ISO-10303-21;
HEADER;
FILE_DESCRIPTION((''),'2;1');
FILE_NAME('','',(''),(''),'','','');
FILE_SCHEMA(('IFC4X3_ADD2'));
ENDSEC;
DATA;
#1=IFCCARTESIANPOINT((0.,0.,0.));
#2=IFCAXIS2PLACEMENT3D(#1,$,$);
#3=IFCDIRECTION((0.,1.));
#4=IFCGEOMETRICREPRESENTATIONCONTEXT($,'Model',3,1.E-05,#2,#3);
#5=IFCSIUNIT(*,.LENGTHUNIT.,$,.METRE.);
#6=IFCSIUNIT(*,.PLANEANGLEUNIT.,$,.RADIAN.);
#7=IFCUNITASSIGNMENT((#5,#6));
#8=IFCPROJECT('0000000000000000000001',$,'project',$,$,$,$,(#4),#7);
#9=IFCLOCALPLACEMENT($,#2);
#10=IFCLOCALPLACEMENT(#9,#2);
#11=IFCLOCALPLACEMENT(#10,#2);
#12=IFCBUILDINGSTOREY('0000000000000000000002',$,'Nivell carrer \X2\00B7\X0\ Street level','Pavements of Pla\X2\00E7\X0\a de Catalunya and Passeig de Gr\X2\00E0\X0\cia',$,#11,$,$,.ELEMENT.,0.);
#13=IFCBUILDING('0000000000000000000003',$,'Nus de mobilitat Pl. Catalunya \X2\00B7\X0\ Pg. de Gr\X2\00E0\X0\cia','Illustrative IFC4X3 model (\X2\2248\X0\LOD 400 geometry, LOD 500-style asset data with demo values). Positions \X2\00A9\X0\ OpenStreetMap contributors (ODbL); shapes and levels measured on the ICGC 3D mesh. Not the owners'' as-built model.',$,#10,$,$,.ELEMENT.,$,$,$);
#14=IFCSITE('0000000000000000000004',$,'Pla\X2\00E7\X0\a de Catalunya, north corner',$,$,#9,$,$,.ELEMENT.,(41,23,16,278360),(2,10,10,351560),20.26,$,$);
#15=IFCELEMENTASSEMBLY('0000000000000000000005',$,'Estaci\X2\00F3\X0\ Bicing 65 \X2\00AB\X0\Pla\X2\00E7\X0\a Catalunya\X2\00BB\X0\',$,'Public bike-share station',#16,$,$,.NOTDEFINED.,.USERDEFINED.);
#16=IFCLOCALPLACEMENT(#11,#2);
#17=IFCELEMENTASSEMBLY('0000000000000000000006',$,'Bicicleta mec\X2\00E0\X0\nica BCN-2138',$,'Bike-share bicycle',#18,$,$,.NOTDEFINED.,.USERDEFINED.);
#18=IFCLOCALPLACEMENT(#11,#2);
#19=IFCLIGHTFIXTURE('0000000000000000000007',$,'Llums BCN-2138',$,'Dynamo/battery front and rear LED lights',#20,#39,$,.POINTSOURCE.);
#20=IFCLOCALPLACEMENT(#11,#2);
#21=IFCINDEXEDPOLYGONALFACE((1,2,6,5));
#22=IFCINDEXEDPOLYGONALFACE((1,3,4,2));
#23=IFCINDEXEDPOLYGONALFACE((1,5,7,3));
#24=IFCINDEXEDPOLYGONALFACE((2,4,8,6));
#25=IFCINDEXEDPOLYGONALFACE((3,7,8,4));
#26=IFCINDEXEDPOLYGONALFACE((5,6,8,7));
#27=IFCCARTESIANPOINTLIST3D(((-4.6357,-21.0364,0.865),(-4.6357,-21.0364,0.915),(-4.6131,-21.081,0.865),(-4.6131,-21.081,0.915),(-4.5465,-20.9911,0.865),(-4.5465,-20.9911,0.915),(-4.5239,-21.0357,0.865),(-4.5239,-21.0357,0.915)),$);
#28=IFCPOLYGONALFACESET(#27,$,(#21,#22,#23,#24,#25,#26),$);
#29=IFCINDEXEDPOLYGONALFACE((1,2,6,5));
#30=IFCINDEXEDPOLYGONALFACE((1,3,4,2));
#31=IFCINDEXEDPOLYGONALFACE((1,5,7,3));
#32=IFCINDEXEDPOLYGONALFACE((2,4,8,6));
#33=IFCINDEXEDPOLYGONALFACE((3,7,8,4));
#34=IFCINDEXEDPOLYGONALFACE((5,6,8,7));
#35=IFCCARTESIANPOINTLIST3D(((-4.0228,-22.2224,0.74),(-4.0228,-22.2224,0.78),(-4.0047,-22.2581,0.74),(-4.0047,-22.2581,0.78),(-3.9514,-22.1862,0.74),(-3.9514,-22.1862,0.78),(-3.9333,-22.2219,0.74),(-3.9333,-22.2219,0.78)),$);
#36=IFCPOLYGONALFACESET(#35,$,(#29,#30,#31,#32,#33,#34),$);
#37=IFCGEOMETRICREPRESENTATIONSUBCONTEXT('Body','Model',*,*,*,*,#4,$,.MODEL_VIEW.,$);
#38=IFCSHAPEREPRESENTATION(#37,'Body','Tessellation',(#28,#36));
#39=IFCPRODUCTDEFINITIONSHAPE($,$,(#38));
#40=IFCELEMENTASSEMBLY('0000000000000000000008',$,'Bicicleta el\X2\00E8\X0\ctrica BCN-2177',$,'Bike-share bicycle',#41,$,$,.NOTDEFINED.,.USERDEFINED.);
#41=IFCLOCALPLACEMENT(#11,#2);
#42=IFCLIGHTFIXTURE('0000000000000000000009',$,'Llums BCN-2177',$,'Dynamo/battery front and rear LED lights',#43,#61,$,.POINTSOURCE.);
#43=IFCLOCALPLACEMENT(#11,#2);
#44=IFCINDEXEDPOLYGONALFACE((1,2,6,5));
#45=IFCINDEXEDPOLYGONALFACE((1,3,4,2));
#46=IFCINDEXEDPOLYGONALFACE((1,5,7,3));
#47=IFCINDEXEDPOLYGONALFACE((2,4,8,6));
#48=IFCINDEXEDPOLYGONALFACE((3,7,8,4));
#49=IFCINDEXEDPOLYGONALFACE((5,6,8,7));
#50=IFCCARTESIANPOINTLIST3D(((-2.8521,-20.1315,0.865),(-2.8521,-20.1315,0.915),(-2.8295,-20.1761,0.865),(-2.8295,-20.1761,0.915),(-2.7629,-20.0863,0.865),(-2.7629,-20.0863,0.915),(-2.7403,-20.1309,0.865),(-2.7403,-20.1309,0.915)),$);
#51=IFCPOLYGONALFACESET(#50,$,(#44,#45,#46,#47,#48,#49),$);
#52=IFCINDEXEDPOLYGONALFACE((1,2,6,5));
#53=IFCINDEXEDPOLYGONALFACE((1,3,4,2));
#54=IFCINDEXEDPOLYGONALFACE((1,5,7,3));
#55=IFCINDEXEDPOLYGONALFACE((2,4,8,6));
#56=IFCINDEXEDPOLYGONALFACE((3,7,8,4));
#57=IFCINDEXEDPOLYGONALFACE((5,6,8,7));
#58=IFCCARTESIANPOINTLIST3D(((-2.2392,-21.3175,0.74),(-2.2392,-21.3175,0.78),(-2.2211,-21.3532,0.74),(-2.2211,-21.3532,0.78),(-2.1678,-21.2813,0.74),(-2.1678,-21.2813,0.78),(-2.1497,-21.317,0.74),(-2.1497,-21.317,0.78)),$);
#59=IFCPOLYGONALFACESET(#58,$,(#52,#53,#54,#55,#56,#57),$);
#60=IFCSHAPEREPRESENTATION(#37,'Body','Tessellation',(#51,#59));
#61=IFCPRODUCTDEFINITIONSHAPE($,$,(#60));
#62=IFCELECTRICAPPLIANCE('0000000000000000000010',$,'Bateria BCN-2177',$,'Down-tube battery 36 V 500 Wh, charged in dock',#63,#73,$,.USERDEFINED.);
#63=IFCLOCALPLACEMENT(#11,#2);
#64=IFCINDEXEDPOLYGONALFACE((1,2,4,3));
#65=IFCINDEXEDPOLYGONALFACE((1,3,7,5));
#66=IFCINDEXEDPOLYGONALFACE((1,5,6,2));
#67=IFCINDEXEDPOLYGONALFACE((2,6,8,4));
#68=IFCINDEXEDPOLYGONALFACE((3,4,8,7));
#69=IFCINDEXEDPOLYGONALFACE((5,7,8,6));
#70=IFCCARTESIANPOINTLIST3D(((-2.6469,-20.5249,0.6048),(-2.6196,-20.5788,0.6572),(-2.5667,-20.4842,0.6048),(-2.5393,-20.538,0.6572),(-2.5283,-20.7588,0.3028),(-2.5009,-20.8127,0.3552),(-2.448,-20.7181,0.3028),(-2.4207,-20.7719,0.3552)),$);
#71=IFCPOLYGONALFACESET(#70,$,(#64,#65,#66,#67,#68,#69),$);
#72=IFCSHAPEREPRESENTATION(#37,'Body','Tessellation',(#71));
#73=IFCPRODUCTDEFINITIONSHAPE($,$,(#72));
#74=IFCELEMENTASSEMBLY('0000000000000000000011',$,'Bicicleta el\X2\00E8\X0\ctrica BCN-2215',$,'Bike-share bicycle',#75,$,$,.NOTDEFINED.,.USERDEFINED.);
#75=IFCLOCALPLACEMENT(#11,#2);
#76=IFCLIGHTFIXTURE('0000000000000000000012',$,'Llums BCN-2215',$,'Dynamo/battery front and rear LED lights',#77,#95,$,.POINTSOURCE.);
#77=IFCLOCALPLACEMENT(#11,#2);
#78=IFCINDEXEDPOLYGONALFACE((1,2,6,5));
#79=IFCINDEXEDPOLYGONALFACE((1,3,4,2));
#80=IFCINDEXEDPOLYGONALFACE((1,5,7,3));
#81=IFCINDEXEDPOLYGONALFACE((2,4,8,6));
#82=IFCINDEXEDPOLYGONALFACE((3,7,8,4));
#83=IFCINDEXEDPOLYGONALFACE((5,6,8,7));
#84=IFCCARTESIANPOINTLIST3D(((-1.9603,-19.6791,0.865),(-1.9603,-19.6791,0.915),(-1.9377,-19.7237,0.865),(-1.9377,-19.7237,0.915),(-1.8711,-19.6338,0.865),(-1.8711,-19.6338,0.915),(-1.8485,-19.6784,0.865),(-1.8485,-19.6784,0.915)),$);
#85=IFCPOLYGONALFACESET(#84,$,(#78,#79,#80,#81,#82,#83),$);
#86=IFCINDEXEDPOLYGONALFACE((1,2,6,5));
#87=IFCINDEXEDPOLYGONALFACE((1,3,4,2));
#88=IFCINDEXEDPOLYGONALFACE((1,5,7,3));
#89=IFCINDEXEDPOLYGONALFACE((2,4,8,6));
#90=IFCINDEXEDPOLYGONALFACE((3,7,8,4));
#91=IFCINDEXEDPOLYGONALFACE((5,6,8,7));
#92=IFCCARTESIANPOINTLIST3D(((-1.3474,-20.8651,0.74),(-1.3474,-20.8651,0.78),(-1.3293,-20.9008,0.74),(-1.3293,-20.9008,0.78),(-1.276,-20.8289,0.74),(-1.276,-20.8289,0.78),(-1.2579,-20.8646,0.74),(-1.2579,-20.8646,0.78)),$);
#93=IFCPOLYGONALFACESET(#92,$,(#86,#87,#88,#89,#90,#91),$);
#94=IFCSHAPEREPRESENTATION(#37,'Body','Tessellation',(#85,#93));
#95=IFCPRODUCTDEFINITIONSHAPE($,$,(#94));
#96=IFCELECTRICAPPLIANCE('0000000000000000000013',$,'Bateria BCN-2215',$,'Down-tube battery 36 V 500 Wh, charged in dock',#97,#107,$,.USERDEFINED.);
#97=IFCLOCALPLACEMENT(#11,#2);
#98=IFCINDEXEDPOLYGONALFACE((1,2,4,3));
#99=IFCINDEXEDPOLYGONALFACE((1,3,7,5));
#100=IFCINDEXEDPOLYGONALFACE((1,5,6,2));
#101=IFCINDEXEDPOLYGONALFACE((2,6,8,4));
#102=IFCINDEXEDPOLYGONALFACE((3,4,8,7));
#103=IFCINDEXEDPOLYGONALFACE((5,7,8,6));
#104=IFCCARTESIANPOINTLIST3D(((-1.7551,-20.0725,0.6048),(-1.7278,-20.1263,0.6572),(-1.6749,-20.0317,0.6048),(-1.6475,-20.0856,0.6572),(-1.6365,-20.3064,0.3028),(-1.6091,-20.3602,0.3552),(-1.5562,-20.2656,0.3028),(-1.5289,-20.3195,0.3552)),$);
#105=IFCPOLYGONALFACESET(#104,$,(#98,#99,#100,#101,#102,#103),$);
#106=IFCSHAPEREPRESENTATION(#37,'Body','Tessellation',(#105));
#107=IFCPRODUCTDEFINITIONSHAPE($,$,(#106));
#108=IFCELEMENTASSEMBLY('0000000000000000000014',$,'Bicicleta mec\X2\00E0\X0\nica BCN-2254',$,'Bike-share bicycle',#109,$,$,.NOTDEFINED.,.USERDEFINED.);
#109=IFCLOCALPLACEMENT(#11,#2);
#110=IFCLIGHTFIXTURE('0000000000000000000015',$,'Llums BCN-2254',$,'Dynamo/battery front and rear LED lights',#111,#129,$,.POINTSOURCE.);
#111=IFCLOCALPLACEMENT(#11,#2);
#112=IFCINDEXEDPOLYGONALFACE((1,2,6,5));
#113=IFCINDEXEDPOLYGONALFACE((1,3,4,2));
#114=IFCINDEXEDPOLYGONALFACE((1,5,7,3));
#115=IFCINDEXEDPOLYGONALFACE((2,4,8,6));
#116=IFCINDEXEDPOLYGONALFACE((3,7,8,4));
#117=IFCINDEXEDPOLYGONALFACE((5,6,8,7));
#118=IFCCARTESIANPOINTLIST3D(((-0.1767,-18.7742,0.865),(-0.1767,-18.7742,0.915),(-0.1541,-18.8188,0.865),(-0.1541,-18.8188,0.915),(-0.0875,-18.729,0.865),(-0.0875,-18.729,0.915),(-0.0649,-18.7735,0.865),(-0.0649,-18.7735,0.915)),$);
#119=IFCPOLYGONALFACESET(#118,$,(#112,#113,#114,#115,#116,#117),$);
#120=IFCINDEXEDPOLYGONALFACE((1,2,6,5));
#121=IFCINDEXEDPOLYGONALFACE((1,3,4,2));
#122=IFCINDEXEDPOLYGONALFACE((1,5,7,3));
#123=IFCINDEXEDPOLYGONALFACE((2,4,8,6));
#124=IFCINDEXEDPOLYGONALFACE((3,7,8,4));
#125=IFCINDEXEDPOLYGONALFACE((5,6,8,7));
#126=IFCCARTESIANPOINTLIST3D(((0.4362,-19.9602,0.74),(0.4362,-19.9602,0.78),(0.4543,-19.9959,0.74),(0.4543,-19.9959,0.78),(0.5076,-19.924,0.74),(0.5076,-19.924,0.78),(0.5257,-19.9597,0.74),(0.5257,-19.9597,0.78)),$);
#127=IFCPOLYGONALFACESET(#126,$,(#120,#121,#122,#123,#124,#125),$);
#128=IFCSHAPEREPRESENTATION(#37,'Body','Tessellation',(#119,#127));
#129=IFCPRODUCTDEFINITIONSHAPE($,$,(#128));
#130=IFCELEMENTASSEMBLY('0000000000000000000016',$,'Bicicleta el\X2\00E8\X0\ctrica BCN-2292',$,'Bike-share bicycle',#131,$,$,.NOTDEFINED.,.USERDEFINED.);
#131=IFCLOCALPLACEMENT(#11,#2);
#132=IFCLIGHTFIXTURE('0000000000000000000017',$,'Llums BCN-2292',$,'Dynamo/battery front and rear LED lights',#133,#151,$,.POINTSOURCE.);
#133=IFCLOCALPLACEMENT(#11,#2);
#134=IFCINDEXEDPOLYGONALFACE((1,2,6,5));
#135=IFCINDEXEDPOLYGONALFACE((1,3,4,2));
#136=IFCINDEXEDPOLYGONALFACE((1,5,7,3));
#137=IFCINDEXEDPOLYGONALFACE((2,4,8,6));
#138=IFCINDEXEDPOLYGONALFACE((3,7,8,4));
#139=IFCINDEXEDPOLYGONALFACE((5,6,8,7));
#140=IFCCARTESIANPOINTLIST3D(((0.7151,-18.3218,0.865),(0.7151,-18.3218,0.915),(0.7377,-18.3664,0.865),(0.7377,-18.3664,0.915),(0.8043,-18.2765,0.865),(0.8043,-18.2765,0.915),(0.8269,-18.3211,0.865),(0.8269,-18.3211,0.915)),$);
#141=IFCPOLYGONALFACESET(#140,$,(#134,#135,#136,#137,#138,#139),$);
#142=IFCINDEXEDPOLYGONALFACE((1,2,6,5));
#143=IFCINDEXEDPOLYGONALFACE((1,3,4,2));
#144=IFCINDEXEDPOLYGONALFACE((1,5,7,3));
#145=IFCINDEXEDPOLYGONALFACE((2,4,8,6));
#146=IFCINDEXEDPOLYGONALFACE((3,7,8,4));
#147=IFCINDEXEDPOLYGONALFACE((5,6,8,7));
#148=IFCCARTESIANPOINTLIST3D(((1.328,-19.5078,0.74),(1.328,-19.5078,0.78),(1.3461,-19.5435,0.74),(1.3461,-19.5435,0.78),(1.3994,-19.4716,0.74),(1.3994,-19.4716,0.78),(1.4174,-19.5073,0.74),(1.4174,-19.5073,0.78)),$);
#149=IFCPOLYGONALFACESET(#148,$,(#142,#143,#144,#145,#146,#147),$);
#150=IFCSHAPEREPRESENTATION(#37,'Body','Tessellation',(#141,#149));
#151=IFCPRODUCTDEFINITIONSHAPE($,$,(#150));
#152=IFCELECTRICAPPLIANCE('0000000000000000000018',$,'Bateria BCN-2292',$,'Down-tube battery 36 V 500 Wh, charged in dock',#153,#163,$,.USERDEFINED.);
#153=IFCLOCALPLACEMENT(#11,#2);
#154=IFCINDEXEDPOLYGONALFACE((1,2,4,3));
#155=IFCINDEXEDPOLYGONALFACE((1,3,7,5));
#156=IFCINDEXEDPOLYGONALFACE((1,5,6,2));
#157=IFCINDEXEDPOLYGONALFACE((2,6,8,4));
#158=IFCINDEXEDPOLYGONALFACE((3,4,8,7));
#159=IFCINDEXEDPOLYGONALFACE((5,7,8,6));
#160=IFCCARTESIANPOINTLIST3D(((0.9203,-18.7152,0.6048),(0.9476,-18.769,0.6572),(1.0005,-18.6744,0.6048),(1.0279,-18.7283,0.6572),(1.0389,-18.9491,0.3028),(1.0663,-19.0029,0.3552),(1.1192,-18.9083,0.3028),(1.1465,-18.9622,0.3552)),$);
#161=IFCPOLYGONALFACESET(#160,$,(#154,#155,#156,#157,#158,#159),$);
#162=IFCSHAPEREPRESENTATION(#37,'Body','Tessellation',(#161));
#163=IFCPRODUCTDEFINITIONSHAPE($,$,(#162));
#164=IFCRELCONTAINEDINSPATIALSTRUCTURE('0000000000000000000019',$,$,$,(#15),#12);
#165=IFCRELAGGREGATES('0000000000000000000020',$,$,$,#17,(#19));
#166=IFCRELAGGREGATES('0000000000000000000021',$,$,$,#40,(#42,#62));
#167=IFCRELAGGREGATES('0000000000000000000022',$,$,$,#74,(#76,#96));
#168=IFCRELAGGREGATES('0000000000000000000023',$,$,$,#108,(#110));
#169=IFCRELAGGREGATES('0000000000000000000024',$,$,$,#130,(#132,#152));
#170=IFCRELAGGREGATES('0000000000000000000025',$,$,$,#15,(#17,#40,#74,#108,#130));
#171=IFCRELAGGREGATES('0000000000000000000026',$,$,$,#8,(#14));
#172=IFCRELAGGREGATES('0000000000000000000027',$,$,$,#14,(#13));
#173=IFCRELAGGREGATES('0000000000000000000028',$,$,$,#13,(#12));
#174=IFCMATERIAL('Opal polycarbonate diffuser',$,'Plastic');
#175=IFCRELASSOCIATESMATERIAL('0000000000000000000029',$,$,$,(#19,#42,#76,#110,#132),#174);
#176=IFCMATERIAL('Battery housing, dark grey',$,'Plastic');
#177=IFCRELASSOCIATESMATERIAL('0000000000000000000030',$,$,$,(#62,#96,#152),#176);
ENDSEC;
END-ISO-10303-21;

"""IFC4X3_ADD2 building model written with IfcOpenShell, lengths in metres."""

from ifc_helpers import new_model, si_unit, direction, frame, origin, origin_2d_with_axis, place, context, subcontext, project, spatial, rectangle, extrude, material, element, aggregate, save


model = new_model("IFC4X3_ADD2")

# Units and contexts
model_context = context("Model", 3, precision=1e-05, world=origin(), true_north=direction((0.0, 1.0)))
body_context = subcontext(model_context, "Body", "Model", "MODEL_VIEW")
ifc_project = project(units=[si_unit("LENGTHUNIT", "METRE"), si_unit("PLANEANGLEUNIT", "RADIAN")], contexts=[model_context])

# Site, building, storey
site_placement = place(None, origin())
site = spatial("IfcSite", under=ifc_project, at=site_placement, Name="Plaça de Catalunya, north corner", CompositionType="ELEMENT", RefLatitude=(41, 23, 16, 278360), RefLongitude=(2, 10, 10, 351560), RefElevation=20.26)
building_placement = place(site_placement, origin())
building = spatial("IfcBuilding", under=site, at=building_placement, Name="Nus de mobilitat Pl. Catalunya · Pg. de Gràcia", Description="Illustrative IFC4X3 model (≈LOD 400 geometry, LOD 500-style asset data with demo values). Positions © OpenStreetMap contributors (ODbL); shapes and levels measured on the ICGC 3D mesh. Not the owners' as-built model.", CompositionType="ELEMENT")
storey_placement = place(building_placement, origin())
storey = spatial("IfcBuildingStorey", under=building, at=storey_placement, Name="Nivell carrer · Street level", Description="Pavements of Plaça de Catalunya and Passeig de Gràcia", CompositionType="ELEMENT", Elevation=0.0)

# Element assemblies, light fixtures, electric appliances
assembly_1_placement = place(building_placement, origin())
assembly_1 = element("IfcElementAssembly", 1, at=assembly_1_placement, inside=storey, Name="Estació Bicing 65 «Plaça Catalunya»", ObjectType="Public bike-share station", AssemblyPlace="NOTDEFINED", PredefinedType="USERDEFINED")
assembly_2_placement = place(building_placement, origin())
assembly_2 = element("IfcElementAssembly", 2, at=assembly_2_placement, Name="Bicicleta mecànica BCN-2138", ObjectType="Bike-share bicycle", AssemblyPlace="NOTDEFINED", PredefinedType="USERDEFINED")
ifc_material_1 = material(Name="Opal polycarbonate diffuser", Category="Plastic")
light_fixture_1_placement = place(building_placement, origin())
light_fixture_1 = element("IfcLightFixture", 3, at=light_fixture_1_placement, material=ifc_material_1, Name="Llums BCN-2138", ObjectType="Dynamo/battery front and rear LED lights", PredefinedType="POINTSOURCE", context=body_context, shape_type="SweptSolid", body=[
    extrude(rectangle(XDim=0.05, YDim=0.1, at=origin_2d_with_axis()), frame((-4.5798, -21.036, 0.915), z_axis=(0.0, 0.0, -1.0), x_axis=(-0.452435, 0.891798, 0.0)), (0.0, 0.0, 1.0), 0.05),
    extrude(rectangle(XDim=0.04, YDim=0.08, at=origin_2d_with_axis()), frame((-3.9781, -22.2221, 0.78), z_axis=(0.0, 0.0, -1.0), x_axis=(-0.452435, 0.891798, 0.0)), (0.0, 0.0, 1.0), 0.04),
])
aggregate(assembly_2, [light_fixture_1])
assembly_3_placement = place(building_placement, origin())
assembly_3 = element("IfcElementAssembly", 4, at=assembly_3_placement, Name="Bicicleta elèctrica BCN-2177", ObjectType="Bike-share bicycle", AssemblyPlace="NOTDEFINED", PredefinedType="USERDEFINED")
light_fixture_2_placement = place(building_placement, origin())
light_fixture_2 = element("IfcLightFixture", 5, at=light_fixture_2_placement, material=ifc_material_1, Name="Llums BCN-2177", ObjectType="Dynamo/battery front and rear LED lights", PredefinedType="POINTSOURCE", context=body_context, shape_type="SweptSolid", body=[
    extrude(rectangle(XDim=0.05, YDim=0.1, at=origin_2d_with_axis()), frame((-2.7962, -20.1312, 0.915), z_axis=(0.0, 0.0, -1.0), x_axis=(-0.452435, 0.891798, 0.0)), (0.0, 0.0, 1.0), 0.05),
    extrude(rectangle(XDim=0.04, YDim=0.08, at=origin_2d_with_axis()), frame((-2.1945, -21.3173, 0.78), z_axis=(0.0, 0.0, -1.0), x_axis=(-0.452435, 0.891798, 0.0)), (0.0, 0.0, 1.0), 0.04),
])
ifc_material_2 = material(Name="Battery housing, dark grey", Category="Plastic")
electric_appliance_1_placement = place(building_placement, origin())
electric_appliance_1 = element("IfcElectricAppliance", 6, at=electric_appliance_1_placement, material=ifc_material_2, Name="Bateria BCN-2177", ObjectType="Down-tube battery 36 V 500 Wh, charged in dock", PredefinedType="USERDEFINED", context=body_context, shape_type="SweptSolid", body=[
    extrude(rectangle(XDim=0.4, YDim=0.09, at=origin_2d_with_axis()), frame((-2.5201, -20.6754, 0.5062), z_axis=(-0.341603, 0.673337, -0.655687), x_axis=(-0.296655, 0.58474, 0.755033)), (0.0, 0.0, 1.0), 0.08),
])
assembly_4_placement = place(building_placement, origin())
assembly_4 = element("IfcElementAssembly", 7, at=assembly_4_placement, Name="Bicicleta elèctrica BCN-2215", ObjectType="Bike-share bicycle", AssemblyPlace="NOTDEFINED", PredefinedType="USERDEFINED")
light_fixture_3_placement = place(building_placement, origin())
light_fixture_3 = element("IfcLightFixture", 8, at=light_fixture_3_placement, material=ifc_material_1, Name="Llums BCN-2215", ObjectType="Dynamo/battery front and rear LED lights", PredefinedType="POINTSOURCE", context=body_context, shape_type="SweptSolid", body=[
    extrude(rectangle(XDim=0.05, YDim=0.1, at=origin_2d_with_axis()), frame((-1.9044, -19.6787, 0.915), z_axis=(0.0, 0.0, -1.0), x_axis=(-0.452435, 0.891798, 0.0)), (0.0, 0.0, 1.0), 0.05),
    extrude(rectangle(XDim=0.04, YDim=0.08, at=origin_2d_with_axis()), frame((-1.3027, -20.8648, 0.78), z_axis=(0.0, 0.0, -1.0), x_axis=(-0.452435, 0.891798, 0.0)), (0.0, 0.0, 1.0), 0.04),
])
electric_appliance_2_placement = place(building_placement, origin())
electric_appliance_2 = element("IfcElectricAppliance", 9, at=electric_appliance_2_placement, material=ifc_material_2, Name="Bateria BCN-2215", ObjectType="Down-tube battery 36 V 500 Wh, charged in dock", PredefinedType="USERDEFINED", context=body_context, shape_type="SweptSolid", body=[
    extrude(rectangle(XDim=0.4, YDim=0.09, at=origin_2d_with_axis()), frame((-1.6283, -20.2229, 0.5062), z_axis=(-0.341603, 0.673337, -0.655687), x_axis=(-0.296655, 0.58474, 0.755033)), (0.0, 0.0, 1.0), 0.08),
])
assembly_5_placement = place(building_placement, origin())
assembly_5 = element("IfcElementAssembly", 10, at=assembly_5_placement, Name="Bicicleta mecànica BCN-2254", ObjectType="Bike-share bicycle", AssemblyPlace="NOTDEFINED", PredefinedType="USERDEFINED")
light_fixture_4_placement = place(building_placement, origin())
light_fixture_4 = element("IfcLightFixture", 11, at=light_fixture_4_placement, material=ifc_material_1, Name="Llums BCN-2254", ObjectType="Dynamo/battery front and rear LED lights", PredefinedType="POINTSOURCE", context=body_context, shape_type="SweptSolid", body=[
    extrude(rectangle(XDim=0.05, YDim=0.1, at=origin_2d_with_axis()), frame((-0.1208, -18.7739, 0.915), z_axis=(0.0, 0.0, -1.0), x_axis=(-0.452435, 0.891798, 0.0)), (0.0, 0.0, 1.0), 0.05),
    extrude(rectangle(XDim=0.04, YDim=0.08, at=origin_2d_with_axis()), frame((0.4809, -19.96, 0.78), z_axis=(0.0, 0.0, -1.0), x_axis=(-0.452435, 0.891798, 0.0)), (0.0, 0.0, 1.0), 0.04),
])
assembly_6_placement = place(building_placement, origin())
assembly_6 = element("IfcElementAssembly", 12, at=assembly_6_placement, Name="Bicicleta elèctrica BCN-2292", ObjectType="Bike-share bicycle", AssemblyPlace="NOTDEFINED", PredefinedType="USERDEFINED")
light_fixture_5_placement = place(building_placement, origin())
light_fixture_5 = element("IfcLightFixture", 13, at=light_fixture_5_placement, material=ifc_material_1, Name="Llums BCN-2292", ObjectType="Dynamo/battery front and rear LED lights", PredefinedType="POINTSOURCE", context=body_context, shape_type="SweptSolid", body=[
    extrude(rectangle(XDim=0.05, YDim=0.1, at=origin_2d_with_axis()), frame((0.771, -18.3214, 0.915), z_axis=(0.0, 0.0, -1.0), x_axis=(-0.452435, 0.891798, 0.0)), (0.0, 0.0, 1.0), 0.05),
    extrude(rectangle(XDim=0.04, YDim=0.08, at=origin_2d_with_axis()), frame((1.3727, -19.5075, 0.78), z_axis=(0.0, 0.0, -1.0), x_axis=(-0.452435, 0.891798, 0.0)), (0.0, 0.0, 1.0), 0.04),
])
electric_appliance_3_placement = place(building_placement, origin())
electric_appliance_3 = element("IfcElectricAppliance", 14, at=electric_appliance_3_placement, material=ifc_material_2, Name="Bateria BCN-2292", ObjectType="Down-tube battery 36 V 500 Wh, charged in dock", PredefinedType="USERDEFINED", context=body_context, shape_type="SweptSolid", body=[
    extrude(rectangle(XDim=0.4, YDim=0.09, at=origin_2d_with_axis()), frame((1.0471, -18.8656, 0.5062), z_axis=(-0.341603, 0.673337, -0.655687), x_axis=(-0.296655, 0.58474, 0.755033)), (0.0, 0.0, 1.0), 0.08),
])
aggregate(assembly_3, [light_fixture_2, electric_appliance_1])
aggregate(assembly_4, [light_fixture_3, electric_appliance_2])
aggregate(assembly_5, [light_fixture_4])
aggregate(assembly_6, [light_fixture_5, electric_appliance_3])
aggregate(assembly_1, [assembly_2, assembly_3, assembly_4, assembly_5, assembly_6])

save(model, "model.ifc")
